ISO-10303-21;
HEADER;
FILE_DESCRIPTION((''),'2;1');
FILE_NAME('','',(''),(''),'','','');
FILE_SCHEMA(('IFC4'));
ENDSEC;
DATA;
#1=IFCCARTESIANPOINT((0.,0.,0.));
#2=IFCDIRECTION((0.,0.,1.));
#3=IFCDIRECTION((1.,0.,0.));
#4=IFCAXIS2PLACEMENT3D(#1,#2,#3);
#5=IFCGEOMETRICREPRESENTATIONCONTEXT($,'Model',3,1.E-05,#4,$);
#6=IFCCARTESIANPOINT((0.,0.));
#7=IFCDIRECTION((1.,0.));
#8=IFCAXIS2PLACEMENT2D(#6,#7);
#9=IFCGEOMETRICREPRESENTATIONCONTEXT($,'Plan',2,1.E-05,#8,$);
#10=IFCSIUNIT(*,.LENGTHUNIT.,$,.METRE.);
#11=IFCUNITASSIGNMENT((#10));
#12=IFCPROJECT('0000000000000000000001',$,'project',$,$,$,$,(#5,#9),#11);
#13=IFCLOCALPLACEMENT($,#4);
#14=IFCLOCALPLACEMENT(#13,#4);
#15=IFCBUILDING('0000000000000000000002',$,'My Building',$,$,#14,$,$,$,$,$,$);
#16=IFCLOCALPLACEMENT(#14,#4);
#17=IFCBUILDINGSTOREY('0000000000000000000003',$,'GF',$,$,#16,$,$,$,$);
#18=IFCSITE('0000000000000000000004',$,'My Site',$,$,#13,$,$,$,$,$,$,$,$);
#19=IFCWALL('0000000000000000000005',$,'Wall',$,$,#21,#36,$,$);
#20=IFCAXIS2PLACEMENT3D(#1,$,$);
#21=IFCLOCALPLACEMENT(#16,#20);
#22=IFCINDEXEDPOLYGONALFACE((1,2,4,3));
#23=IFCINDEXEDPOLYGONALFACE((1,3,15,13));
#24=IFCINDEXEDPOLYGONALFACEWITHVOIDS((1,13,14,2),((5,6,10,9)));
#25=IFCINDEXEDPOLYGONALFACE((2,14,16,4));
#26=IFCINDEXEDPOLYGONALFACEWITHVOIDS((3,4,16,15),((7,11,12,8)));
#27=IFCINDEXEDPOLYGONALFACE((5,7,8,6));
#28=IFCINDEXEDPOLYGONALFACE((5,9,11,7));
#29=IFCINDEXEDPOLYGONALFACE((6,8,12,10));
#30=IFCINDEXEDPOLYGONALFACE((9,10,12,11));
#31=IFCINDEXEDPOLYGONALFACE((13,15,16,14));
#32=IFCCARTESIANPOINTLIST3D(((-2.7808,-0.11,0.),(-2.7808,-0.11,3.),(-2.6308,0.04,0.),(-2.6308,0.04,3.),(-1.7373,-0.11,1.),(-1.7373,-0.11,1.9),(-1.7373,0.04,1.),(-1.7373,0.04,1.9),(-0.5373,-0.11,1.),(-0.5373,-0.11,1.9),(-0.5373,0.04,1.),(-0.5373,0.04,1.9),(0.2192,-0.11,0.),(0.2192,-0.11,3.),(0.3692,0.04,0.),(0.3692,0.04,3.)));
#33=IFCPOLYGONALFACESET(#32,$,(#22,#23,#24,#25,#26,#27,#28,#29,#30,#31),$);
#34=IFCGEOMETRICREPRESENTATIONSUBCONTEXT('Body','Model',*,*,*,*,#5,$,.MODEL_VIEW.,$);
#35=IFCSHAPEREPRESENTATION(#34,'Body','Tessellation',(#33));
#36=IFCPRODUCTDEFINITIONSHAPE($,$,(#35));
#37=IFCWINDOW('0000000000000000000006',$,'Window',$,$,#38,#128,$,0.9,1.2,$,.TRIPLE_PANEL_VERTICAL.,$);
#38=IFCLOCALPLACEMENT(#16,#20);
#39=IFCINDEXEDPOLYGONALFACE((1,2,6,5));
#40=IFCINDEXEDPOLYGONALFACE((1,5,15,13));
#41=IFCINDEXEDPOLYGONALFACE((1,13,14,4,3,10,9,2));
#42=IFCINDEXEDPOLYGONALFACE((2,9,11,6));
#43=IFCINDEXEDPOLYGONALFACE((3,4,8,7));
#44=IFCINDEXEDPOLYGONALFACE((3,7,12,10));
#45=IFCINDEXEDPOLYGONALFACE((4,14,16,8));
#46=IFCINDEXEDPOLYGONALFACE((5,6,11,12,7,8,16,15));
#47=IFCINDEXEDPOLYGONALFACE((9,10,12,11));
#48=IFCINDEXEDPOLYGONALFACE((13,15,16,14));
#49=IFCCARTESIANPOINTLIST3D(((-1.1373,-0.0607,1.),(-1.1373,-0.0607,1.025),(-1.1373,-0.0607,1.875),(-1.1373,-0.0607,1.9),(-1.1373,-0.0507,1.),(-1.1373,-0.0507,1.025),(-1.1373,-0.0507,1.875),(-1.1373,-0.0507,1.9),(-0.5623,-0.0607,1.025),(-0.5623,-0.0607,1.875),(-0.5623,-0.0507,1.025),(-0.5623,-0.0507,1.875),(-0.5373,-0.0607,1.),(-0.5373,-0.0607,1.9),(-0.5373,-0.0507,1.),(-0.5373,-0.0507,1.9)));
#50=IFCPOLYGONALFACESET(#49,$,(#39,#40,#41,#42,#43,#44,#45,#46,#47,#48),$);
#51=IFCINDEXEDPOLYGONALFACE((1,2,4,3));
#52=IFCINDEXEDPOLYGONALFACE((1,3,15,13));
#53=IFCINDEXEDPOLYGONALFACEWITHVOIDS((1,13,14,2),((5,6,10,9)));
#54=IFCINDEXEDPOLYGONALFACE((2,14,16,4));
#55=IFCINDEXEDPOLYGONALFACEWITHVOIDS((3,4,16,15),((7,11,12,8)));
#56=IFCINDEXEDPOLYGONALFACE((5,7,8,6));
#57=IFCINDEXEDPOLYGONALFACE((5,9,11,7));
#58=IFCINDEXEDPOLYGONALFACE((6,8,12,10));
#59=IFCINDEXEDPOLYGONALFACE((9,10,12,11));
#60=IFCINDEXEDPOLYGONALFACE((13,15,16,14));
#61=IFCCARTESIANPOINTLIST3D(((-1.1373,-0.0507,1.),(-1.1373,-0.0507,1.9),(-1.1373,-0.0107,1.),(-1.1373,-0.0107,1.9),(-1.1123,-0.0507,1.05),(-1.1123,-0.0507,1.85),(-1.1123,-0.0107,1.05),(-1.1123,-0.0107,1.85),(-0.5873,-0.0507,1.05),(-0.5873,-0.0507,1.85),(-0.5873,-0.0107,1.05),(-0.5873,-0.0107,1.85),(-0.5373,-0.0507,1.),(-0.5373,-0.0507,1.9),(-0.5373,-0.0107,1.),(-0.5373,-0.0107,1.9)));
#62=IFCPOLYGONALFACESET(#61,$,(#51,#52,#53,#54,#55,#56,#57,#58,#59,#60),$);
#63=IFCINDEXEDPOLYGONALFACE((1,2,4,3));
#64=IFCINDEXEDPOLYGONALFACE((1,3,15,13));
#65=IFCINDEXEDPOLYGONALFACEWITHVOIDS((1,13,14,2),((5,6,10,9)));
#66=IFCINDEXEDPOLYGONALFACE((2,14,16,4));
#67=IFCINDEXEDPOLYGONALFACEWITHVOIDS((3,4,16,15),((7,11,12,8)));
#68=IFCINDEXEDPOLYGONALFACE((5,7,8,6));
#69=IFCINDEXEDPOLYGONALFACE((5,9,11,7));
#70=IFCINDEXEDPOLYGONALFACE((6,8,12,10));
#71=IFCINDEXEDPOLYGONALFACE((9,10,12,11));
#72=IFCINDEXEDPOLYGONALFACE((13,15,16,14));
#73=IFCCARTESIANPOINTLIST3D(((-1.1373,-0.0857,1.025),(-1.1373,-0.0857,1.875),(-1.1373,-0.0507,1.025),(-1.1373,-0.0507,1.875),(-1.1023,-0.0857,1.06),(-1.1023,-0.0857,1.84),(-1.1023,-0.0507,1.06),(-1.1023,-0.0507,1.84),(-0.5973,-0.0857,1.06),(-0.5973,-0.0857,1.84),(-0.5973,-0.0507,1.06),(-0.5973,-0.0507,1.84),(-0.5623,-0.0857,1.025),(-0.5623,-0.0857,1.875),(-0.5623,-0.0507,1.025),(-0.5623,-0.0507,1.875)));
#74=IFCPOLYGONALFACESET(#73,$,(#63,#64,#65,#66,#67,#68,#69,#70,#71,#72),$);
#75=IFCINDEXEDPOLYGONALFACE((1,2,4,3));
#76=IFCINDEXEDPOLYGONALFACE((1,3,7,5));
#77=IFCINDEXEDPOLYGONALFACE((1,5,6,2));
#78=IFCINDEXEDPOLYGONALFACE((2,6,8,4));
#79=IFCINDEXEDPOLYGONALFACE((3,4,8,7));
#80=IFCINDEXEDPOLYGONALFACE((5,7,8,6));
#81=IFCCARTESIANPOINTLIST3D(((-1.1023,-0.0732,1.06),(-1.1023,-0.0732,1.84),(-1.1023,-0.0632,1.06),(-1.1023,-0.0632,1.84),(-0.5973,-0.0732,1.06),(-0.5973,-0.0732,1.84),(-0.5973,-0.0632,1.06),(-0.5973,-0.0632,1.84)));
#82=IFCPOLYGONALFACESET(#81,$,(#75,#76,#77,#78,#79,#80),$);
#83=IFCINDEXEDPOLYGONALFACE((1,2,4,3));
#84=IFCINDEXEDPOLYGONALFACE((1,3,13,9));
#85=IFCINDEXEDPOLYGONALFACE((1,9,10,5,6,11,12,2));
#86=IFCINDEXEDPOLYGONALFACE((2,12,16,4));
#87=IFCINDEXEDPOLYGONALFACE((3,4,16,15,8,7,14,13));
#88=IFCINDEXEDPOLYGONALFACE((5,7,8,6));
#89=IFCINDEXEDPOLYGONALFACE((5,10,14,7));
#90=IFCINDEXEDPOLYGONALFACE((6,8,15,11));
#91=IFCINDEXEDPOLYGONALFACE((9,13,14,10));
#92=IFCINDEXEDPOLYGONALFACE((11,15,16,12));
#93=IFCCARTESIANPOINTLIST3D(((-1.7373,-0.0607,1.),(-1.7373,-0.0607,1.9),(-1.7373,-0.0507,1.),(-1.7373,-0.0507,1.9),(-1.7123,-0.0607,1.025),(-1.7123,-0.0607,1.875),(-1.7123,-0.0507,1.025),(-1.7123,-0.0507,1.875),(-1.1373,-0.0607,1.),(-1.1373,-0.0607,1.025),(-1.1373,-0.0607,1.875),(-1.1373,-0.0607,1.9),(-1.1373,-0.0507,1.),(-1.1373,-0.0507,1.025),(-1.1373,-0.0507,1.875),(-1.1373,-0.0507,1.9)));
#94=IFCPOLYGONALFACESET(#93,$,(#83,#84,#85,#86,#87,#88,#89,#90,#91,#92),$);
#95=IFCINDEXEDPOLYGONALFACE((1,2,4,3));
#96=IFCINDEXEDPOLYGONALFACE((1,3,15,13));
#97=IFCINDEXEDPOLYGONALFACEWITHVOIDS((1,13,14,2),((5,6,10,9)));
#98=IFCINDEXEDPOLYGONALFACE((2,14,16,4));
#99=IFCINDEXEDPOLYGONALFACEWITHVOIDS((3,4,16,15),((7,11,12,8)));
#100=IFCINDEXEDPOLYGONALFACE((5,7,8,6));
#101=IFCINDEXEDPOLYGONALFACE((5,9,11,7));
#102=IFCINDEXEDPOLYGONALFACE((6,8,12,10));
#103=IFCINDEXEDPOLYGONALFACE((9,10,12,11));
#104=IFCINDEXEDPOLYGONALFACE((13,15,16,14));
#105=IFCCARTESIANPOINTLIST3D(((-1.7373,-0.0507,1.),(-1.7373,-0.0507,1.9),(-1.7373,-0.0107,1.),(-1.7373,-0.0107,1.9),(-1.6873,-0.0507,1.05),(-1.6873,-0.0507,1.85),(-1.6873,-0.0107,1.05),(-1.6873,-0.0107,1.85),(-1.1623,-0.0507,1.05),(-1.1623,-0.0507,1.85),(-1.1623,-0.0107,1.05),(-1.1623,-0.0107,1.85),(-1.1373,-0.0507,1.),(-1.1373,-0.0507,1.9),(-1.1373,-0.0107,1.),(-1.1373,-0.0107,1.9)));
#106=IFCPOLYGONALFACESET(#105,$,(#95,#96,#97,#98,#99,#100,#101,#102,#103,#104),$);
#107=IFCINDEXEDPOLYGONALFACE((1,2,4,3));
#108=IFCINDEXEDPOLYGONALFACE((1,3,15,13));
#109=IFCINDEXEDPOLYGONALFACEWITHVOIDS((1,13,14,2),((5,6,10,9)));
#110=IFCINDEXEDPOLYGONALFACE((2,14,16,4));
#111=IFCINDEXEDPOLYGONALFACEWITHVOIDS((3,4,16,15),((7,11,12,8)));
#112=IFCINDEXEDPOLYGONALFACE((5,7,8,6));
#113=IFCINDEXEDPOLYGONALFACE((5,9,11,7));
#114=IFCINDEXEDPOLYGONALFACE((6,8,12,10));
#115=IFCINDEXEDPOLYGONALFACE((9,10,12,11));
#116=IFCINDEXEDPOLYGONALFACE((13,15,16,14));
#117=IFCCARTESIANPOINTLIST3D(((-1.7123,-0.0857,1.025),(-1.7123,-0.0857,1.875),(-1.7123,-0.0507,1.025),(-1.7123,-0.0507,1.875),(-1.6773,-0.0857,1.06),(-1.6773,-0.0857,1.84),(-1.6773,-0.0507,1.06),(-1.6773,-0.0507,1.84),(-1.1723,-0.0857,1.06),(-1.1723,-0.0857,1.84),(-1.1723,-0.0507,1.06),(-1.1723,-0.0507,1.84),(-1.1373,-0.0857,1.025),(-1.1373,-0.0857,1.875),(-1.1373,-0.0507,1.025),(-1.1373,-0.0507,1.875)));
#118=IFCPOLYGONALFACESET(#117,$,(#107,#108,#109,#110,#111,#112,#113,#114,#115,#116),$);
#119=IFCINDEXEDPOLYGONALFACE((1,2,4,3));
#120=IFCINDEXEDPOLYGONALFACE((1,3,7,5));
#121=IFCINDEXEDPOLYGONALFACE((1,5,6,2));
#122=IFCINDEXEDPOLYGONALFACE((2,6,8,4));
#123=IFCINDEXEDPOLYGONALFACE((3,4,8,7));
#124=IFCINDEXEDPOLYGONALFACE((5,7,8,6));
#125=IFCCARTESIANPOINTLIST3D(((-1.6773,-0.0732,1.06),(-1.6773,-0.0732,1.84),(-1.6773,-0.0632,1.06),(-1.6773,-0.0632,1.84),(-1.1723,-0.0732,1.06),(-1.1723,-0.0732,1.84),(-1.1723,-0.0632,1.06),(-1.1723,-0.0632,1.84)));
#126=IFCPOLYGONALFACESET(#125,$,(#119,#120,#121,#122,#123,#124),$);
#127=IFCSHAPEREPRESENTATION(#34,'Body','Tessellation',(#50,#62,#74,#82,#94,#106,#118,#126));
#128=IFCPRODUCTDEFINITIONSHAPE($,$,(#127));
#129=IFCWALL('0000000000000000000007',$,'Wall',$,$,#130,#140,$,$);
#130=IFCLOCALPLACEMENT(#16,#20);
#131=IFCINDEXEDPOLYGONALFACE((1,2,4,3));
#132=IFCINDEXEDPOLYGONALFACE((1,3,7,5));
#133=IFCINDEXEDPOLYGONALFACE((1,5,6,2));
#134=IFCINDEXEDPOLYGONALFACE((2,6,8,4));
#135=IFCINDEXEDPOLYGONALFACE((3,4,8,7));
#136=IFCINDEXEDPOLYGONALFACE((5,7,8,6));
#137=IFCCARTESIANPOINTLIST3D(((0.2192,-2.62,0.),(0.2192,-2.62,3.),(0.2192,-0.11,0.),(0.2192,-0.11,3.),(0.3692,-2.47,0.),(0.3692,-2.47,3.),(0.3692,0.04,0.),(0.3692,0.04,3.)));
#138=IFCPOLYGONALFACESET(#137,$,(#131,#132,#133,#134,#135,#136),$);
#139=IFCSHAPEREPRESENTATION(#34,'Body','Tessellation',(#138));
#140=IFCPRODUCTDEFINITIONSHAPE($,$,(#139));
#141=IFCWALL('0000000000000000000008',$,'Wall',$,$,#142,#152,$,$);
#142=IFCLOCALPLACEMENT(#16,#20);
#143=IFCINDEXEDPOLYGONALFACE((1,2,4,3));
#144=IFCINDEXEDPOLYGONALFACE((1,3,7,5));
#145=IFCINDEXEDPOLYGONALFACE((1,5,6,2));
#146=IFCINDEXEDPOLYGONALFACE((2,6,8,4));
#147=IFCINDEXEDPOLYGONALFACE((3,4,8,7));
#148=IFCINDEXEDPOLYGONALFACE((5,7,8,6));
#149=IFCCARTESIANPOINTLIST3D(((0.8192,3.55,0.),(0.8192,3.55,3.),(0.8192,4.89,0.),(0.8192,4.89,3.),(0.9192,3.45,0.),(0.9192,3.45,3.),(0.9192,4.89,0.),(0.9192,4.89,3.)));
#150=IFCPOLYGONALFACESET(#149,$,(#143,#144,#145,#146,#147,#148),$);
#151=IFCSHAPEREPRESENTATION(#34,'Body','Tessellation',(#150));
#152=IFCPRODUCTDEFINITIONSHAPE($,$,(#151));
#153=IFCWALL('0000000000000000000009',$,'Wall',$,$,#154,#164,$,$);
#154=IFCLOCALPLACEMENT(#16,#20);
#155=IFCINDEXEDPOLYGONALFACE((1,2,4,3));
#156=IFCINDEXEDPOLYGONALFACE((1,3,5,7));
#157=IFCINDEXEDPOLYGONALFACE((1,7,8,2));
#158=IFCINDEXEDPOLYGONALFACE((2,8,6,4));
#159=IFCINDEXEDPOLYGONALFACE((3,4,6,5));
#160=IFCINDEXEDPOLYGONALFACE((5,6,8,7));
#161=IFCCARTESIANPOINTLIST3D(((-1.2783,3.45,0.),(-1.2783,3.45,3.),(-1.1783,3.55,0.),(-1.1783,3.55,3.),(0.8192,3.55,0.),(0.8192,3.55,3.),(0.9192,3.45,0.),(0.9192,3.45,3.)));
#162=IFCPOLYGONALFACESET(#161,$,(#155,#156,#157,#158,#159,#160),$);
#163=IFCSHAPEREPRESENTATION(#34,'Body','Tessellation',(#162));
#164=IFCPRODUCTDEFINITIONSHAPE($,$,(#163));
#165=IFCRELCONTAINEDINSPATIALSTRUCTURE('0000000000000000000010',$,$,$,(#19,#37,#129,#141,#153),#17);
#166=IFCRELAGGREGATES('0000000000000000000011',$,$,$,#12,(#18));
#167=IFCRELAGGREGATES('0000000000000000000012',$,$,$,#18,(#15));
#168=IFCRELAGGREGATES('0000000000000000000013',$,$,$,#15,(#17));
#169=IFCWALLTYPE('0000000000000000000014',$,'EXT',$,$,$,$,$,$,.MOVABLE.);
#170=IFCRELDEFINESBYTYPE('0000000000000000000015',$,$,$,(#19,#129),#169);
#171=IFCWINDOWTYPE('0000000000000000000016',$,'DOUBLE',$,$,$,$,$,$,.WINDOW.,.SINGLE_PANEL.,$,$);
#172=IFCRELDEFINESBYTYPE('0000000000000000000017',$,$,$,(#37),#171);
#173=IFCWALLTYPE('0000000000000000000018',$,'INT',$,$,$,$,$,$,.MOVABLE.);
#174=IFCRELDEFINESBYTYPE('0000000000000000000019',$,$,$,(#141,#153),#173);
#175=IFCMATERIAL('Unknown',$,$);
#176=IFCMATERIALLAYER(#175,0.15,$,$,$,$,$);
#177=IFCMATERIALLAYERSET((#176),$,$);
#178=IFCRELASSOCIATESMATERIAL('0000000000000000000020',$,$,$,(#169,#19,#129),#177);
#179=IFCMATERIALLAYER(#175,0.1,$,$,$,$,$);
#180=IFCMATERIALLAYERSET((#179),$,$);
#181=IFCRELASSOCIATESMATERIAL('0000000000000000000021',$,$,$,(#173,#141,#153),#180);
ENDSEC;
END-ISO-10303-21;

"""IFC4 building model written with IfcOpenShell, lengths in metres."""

from ifc_helpers import new_model, entity, si_unit, frame, origin_with_axes, origin_2d_with_axis, place, context, subcontext, project, spatial, line, indexed_curve, outline, extrude, shape, source, transform, mapped, material, layer, layer_set, layer_usage, type_object, type_shapes, element, fill, save


model = new_model("IFC4")

# Units and contexts
model_context = context("Model", 3, precision=1e-05, world=origin_with_axes())
plan_context = context("Plan", 2, precision=1e-05, world=origin_2d_with_axis())
body_context_1 = subcontext(model_context, "Body", "Model", "MODEL_VIEW")
body_context_2 = subcontext(plan_context, "Body", "Plan", "PLAN_VIEW")
ifc_project = project(units=[si_unit("LENGTHUNIT", "METRE")], contexts=[model_context, plan_context])

# Site, building, storey
site_placement = place(None, origin_with_axes())
site = spatial("IfcSite", under=ifc_project, at=site_placement, Name="My Site")
building_placement = place(site_placement, origin_with_axes())
building = spatial("IfcBuilding", under=site, at=building_placement, Name="My Building")
storey_placement = place(building_placement, origin_with_axes())
storey = spatial("IfcBuildingStorey", under=building, at=storey_placement, Name="GF")

# Shared definitions
ifc_material = material(Name="Unknown")

# Shared definitions
ifc_layer_1 = layer(ifc_material, 0.15)
ifc_layer_set_1 = layer_set([ifc_layer_1])
wall_type_1 = type_object("IfcWallType", Name="EXT", PredefinedType="MOVABLE", material=ifc_layer_set_1)

# Wall, opening, window
ifc_layer_usage_1 = layer_usage(ifc_layer_set_1, "AXIS2", "POSITIVE", 0.0)
wall_1_placement = place(storey_placement, frame((-2.7808, -0.11, 0.0), z_axis=(0.0, 0.0, 1.0), x_axis=(1.0, 0.0, 0.0)))
wall_1 = element("IfcWall", 1, at=wall_1_placement, inside=storey, type_object=wall_type_1, material=ifc_layer_usage_1, Name="Wall", context=body_context_1, shape_type="SweptSolid", body=[
    extrude(outline(indexed_curve([(0.0, 0.0), (0.15, 0.15), (3.15, 0.15), (3.0, 0.0)], segments=[line(1, 2, 3, 4, 1)])), origin_with_axes(), (0.0, 0.0, 1.0), 3.0),
])
placement_1 = place(storey_placement, frame((-0.5373, 0.0393, 1.0), z_axis=(0.0, 0.0, 1.0), x_axis=(-1.0, 0.000001, 0.0)))
opening_1 = element("IfcOpeningElement", 2, at=placement_1, cuts=wall_1, PredefinedType="OPENING", context=body_context_1, shape_type="SweptSolid", body=[
    extrude(outline(indexed_curve([(0.0, 0.0), (1.2, 0.0), (1.2, 0.9), (0.0, 0.9)], segments=[line(1, 2, 3, 4, 1)])), frame((0.0, -0.6, 0.0), z_axis=(0.0, -1.0, 0.0), x_axis=(1.0, 0.0, 0.0)), (0.0, 0.0, -1.0), 1.2),
])
window_type_1 = type_object("IfcWindowType", Name="DOUBLE", PartitioningType="SINGLE_PANEL", PredefinedType="WINDOW")
shared_shape_1 = source(origin_with_axes(), body_context_1, "Body", "SweptSolid", [
    extrude(outline(indexed_curve([(0.6, 0.0), (0.0, 0.0), (0.0, 0.9), (0.6, 0.9), (0.6, 0.875), (0.025, 0.875), (0.025, 0.025), (0.6, 0.025)], segments=[line(1, 2, 3, 4, 5, 6, 7, 8, 1)])), frame((0.0, 0.09, 0.0), z_axis=(0.0, -1.0, 0.0), x_axis=(1.0, 0.0, 0.0)), (0.0, 0.0, -1.0), 0.01),
    extrude(outline(indexed_curve([(0.0, 0.0), (0.6, 0.0), (0.6, 0.9), (0.0, 0.9)], segments=[line(1, 2, 3, 4, 1)]), holes=[indexed_curve([(0.05, 0.05), (0.575, 0.05), (0.575, 0.85), (0.05, 0.85)], segments=[line(1, 2, 3, 4, 1)])]), frame((0.0, 0.05, 0.0), z_axis=(0.0, -1.0, 0.0), x_axis=(1.0, 0.0, 0.0)), (0.0, 0.0, -1.0), 0.04),
    extrude(outline(indexed_curve([(0.0, 0.0), (0.575, 0.0), (0.575, 0.85), (0.0, 0.85)], segments=[line(1, 2, 3, 4, 1)]), holes=[indexed_curve([(0.035, 0.035), (0.54, 0.035), (0.54, 0.815), (0.035, 0.815)], segments=[line(1, 2, 3, 4, 1)])]), frame((0.025, 0.09, 0.025), z_axis=(0.0, -1.0, 0.0), x_axis=(1.0, 0.0, 0.0)), (0.0, 0.0, -1.0), 0.035),
    extrude(outline(indexed_curve([(0.035, 0.035), (0.54, 0.035), (0.54, 0.815), (0.035, 0.815)], segments=[line(1, 2, 3, 4, 1)])), frame((0.025, 0.1025, 0.025), z_axis=(0.0, -1.0, 0.0), x_axis=(1.0, 0.0, 0.0)), (0.0, 0.0, -1.0), 0.01),
    extrude(outline(indexed_curve([(0.0, 0.9), (0.6, 0.9), (0.6, 0.0), (0.0, 0.0), (0.0, 0.025), (0.575, 0.025), (0.575, 0.875), (0.0, 0.875)], segments=[line(1, 2, 3, 4, 5, 6, 7, 8, 1)])), frame((0.6, 0.09, 0.0), z_axis=(0.0, -1.0, 0.0), x_axis=(1.0, 0.0, 0.0)), (0.0, 0.0, -1.0), 0.01),
    extrude(outline(indexed_curve([(0.0, 0.0), (0.6, 0.0), (0.6, 0.9), (0.0, 0.9)], segments=[line(1, 2, 3, 4, 1)]), holes=[indexed_curve([(0.025, 0.05), (0.55, 0.05), (0.55, 0.85), (0.025, 0.85)], segments=[line(1, 2, 3, 4, 1)])]), frame((0.6, 0.05, 0.0), z_axis=(0.0, -1.0, 0.0), x_axis=(1.0, 0.0, 0.0)), (0.0, 0.0, -1.0), 0.04),
    extrude(outline(indexed_curve([(0.0, 0.0), (0.575, 0.0), (0.575, 0.85), (0.0, 0.85)], segments=[line(1, 2, 3, 4, 1)]), holes=[indexed_curve([(0.035, 0.035), (0.54, 0.035), (0.54, 0.815), (0.035, 0.815)], segments=[line(1, 2, 3, 4, 1)])]), frame((0.6, 0.09, 0.025), z_axis=(0.0, -1.0, 0.0), x_axis=(1.0, 0.0, 0.0)), (0.0, 0.0, -1.0), 0.035),
    extrude(outline(indexed_curve([(0.035, 0.815), (0.54, 0.815), (0.54, 0.035), (0.035, 0.035), (0.035, 0.815)])), frame((0.6, 0.1025, 0.025), z_axis=(0.0, -1.0, 0.0), x_axis=(1.0, 0.0, 0.0)), (0.0, 0.0, -1.0), 0.01),
])
shared_shape_2 = source(origin_with_axes(), body_context_2, "Body", "Curve2D", [
    entity("IfcIndexedPolyCurve", entity("IfcCartesianPointList2D", [[0.05, 0.05], [0.575, 0.05]])),
    entity("IfcIndexedPolyCurve", entity("IfcCartesianPointList2D", [[0.0, 0.1], [0.025, 0.1], [0.025, 0.09], [0.05, 0.09], [0.05, 0.05], [0.0, 0.05]]), [entity("IfcLineIndex", [1, 2, 3, 4, 5, 6, 1])]),
    entity("IfcIndexedPolyCurve", entity("IfcCartesianPointList2D", [[0.6, 0.1], [0.6, 0.1], [0.6, 0.09], [0.575, 0.09], [0.575, 0.05], [0.6, 0.05]])),
    entity("IfcIndexedPolyCurve", entity("IfcCartesianPointList2D", [[0.025, 0.09], [0.06, 0.09], [0.06, 0.125], [0.025, 0.125]]), [entity("IfcLineIndex", [1, 2, 3, 4, 1])]),
    entity("IfcIndexedPolyCurve", entity("IfcCartesianPointList2D", [[0.6, 0.09], [0.565, 0.09], [0.565, 0.125], [0.6, 0.125]]), [entity("IfcLineIndex", [1, 2, 3, 4, 1])]),
    entity("IfcIndexedPolyCurve", entity("IfcCartesianPointList2D", [[0.06, 0.09], [0.565, 0.09]])),
    entity("IfcIndexedPolyCurve", entity("IfcCartesianPointList2D", [[0.06, 0.125], [0.565, 0.125]])),
    entity("IfcIndexedPolyCurve", entity("IfcCartesianPointList2D", [[0.06, 0.1075], [0.565, 0.1075]])),
    entity("IfcIndexedPolyCurve", entity("IfcCartesianPointList2D", [[0.625, 0.05], [1.15, 0.05]])),
    entity("IfcIndexedPolyCurve", entity("IfcCartesianPointList2D", [[0.6, 0.1], [0.6, 0.1], [0.6, 0.09], [0.625, 0.09], [0.625, 0.05], [0.6, 0.05]])),
    entity("IfcIndexedPolyCurve", entity("IfcCartesianPointList2D", [[1.2, 0.1], [1.175, 0.1], [1.175, 0.09], [1.15, 0.09], [1.15, 0.05], [1.2, 0.05]]), [entity("IfcLineIndex", [1, 2, 3, 4, 5, 6, 1])]),
    entity("IfcIndexedPolyCurve", entity("IfcCartesianPointList2D", [[0.6, 0.09], [0.635, 0.09], [0.635, 0.125], [0.6, 0.125]]), [entity("IfcLineIndex", [1, 2, 3, 4, 1])]),
    entity("IfcIndexedPolyCurve", entity("IfcCartesianPointList2D", [[1.175, 0.09], [1.14, 0.09], [1.14, 0.125], [1.175, 0.125]]), [entity("IfcLineIndex", [1, 2, 3, 4, 1])]),
    entity("IfcIndexedPolyCurve", entity("IfcCartesianPointList2D", [[0.635, 0.09], [1.14, 0.09]])),
    entity("IfcIndexedPolyCurve", entity("IfcCartesianPointList2D", [[0.635, 0.125], [1.14, 0.125]])),
    entity("IfcIndexedPolyCurve", entity("IfcCartesianPointList2D", [[0.635, 0.1075], [1.14, 0.1075]])),
])
type_shapes(window_type_1, [shared_shape_1, shared_shape_2])
window_1 = element("IfcWindow", 3, at=placement_1, inside=storey, type_object=window_type_1, Name="Window", OverallHeight=0.9, OverallWidth=1.2, PartitioningType="TRIPLE_PANEL_VERTICAL", shapes=[
    shape(body_context_1, "Body", "MappedRepresentation", [mapped(shared_shape_1, transform((0.0, 0.0, 0.0), x_axis=(1.0, 0.0, 0.0), y_axis=(0.0, 1.0, 0.0), z_axis=(0.0, 0.0, 1.0), scale=1.0))]),
    shape(body_context_2, "Body", "MappedRepresentation", [mapped(shared_shape_2, transform((0.0, 0.0, 0.0), x_axis=(1.0, 0.0, 0.0), y_axis=(0.0, 1.0, 0.0), z_axis=(0.0, 0.0, 1.0), scale=1.0))]),
])
fill(opening_1, window_1)

# Walls
ifc_layer_usage_2 = layer_usage(ifc_layer_set_1, "AXIS2", "POSITIVE", 0.0)
wall_2_placement = place(storey_placement, frame((0.2192, -0.11, 0.0), z_axis=(0.0, 0.0, 1.0), x_axis=(0.0, -1.0, 0.0)))
element("IfcWall", 4, at=wall_2_placement, inside=storey, type_object=wall_type_1, material=ifc_layer_usage_2, Name="Wall", context=body_context_1, shape_type="SweptSolid", body=[
    extrude(outline(indexed_curve([(0.0, 0.0), (-0.15, 0.15), (2.36, 0.15), (2.51, 0.0)], segments=[line(1, 2, 3, 4, 1)])), origin_with_axes(), (0.0, 0.0, 1.0), 3.0),
])
ifc_layer_2 = layer(ifc_material, 0.1)
ifc_layer_set_2 = layer_set([ifc_layer_2])
ifc_layer_usage_3 = layer_usage(ifc_layer_set_2, "AXIS2", "POSITIVE", -0.1)
wall_type_2 = type_object("IfcWallType", Name="INT", PredefinedType="MOVABLE", material=ifc_layer_set_2)
wall_3_placement = place(storey_placement, frame((0.9192, 4.89, 0.0), z_axis=(0.0, 0.0, 1.0), x_axis=(0.0, -1.0, 0.0)))
element("IfcWall", 5, at=wall_3_placement, inside=storey, type_object=wall_type_2, material=ifc_layer_usage_3, Name="Wall", context=body_context_1, shape_type="SweptSolid", body=[
    extrude(outline(indexed_curve([(0.0, -0.1), (0.0, 0.0), (1.44, 0.0), (1.34, -0.1)], segments=[line(1, 2, 3, 4, 1)])), origin_with_axes(), (0.0, 0.0, 1.0), 3.0),
])
ifc_layer_usage_4 = layer_usage(ifc_layer_set_2, "AXIS2", "POSITIVE", -0.1)
wall_4_placement = place(storey_placement, frame((0.9192, 3.45, 0.0), z_axis=(0.0, 0.0, 1.0), x_axis=(-1.0, 0.0, 0.0)))
element("IfcWall", 6, at=wall_4_placement, inside=storey, type_object=wall_type_2, material=ifc_layer_usage_4, Name="Wall", context=body_context_1, shape_type="SweptSolid", body=[
    extrude(outline(indexed_curve([(0.1, -0.1), (0.0, 0.0), (2.1975, 0.0), (2.0975, -0.1)], segments=[line(1, 2, 3, 4, 1)])), origin_with_axes(), (0.0, 0.0, 1.0), 3.0),
])

save(model, "model.ifc")
